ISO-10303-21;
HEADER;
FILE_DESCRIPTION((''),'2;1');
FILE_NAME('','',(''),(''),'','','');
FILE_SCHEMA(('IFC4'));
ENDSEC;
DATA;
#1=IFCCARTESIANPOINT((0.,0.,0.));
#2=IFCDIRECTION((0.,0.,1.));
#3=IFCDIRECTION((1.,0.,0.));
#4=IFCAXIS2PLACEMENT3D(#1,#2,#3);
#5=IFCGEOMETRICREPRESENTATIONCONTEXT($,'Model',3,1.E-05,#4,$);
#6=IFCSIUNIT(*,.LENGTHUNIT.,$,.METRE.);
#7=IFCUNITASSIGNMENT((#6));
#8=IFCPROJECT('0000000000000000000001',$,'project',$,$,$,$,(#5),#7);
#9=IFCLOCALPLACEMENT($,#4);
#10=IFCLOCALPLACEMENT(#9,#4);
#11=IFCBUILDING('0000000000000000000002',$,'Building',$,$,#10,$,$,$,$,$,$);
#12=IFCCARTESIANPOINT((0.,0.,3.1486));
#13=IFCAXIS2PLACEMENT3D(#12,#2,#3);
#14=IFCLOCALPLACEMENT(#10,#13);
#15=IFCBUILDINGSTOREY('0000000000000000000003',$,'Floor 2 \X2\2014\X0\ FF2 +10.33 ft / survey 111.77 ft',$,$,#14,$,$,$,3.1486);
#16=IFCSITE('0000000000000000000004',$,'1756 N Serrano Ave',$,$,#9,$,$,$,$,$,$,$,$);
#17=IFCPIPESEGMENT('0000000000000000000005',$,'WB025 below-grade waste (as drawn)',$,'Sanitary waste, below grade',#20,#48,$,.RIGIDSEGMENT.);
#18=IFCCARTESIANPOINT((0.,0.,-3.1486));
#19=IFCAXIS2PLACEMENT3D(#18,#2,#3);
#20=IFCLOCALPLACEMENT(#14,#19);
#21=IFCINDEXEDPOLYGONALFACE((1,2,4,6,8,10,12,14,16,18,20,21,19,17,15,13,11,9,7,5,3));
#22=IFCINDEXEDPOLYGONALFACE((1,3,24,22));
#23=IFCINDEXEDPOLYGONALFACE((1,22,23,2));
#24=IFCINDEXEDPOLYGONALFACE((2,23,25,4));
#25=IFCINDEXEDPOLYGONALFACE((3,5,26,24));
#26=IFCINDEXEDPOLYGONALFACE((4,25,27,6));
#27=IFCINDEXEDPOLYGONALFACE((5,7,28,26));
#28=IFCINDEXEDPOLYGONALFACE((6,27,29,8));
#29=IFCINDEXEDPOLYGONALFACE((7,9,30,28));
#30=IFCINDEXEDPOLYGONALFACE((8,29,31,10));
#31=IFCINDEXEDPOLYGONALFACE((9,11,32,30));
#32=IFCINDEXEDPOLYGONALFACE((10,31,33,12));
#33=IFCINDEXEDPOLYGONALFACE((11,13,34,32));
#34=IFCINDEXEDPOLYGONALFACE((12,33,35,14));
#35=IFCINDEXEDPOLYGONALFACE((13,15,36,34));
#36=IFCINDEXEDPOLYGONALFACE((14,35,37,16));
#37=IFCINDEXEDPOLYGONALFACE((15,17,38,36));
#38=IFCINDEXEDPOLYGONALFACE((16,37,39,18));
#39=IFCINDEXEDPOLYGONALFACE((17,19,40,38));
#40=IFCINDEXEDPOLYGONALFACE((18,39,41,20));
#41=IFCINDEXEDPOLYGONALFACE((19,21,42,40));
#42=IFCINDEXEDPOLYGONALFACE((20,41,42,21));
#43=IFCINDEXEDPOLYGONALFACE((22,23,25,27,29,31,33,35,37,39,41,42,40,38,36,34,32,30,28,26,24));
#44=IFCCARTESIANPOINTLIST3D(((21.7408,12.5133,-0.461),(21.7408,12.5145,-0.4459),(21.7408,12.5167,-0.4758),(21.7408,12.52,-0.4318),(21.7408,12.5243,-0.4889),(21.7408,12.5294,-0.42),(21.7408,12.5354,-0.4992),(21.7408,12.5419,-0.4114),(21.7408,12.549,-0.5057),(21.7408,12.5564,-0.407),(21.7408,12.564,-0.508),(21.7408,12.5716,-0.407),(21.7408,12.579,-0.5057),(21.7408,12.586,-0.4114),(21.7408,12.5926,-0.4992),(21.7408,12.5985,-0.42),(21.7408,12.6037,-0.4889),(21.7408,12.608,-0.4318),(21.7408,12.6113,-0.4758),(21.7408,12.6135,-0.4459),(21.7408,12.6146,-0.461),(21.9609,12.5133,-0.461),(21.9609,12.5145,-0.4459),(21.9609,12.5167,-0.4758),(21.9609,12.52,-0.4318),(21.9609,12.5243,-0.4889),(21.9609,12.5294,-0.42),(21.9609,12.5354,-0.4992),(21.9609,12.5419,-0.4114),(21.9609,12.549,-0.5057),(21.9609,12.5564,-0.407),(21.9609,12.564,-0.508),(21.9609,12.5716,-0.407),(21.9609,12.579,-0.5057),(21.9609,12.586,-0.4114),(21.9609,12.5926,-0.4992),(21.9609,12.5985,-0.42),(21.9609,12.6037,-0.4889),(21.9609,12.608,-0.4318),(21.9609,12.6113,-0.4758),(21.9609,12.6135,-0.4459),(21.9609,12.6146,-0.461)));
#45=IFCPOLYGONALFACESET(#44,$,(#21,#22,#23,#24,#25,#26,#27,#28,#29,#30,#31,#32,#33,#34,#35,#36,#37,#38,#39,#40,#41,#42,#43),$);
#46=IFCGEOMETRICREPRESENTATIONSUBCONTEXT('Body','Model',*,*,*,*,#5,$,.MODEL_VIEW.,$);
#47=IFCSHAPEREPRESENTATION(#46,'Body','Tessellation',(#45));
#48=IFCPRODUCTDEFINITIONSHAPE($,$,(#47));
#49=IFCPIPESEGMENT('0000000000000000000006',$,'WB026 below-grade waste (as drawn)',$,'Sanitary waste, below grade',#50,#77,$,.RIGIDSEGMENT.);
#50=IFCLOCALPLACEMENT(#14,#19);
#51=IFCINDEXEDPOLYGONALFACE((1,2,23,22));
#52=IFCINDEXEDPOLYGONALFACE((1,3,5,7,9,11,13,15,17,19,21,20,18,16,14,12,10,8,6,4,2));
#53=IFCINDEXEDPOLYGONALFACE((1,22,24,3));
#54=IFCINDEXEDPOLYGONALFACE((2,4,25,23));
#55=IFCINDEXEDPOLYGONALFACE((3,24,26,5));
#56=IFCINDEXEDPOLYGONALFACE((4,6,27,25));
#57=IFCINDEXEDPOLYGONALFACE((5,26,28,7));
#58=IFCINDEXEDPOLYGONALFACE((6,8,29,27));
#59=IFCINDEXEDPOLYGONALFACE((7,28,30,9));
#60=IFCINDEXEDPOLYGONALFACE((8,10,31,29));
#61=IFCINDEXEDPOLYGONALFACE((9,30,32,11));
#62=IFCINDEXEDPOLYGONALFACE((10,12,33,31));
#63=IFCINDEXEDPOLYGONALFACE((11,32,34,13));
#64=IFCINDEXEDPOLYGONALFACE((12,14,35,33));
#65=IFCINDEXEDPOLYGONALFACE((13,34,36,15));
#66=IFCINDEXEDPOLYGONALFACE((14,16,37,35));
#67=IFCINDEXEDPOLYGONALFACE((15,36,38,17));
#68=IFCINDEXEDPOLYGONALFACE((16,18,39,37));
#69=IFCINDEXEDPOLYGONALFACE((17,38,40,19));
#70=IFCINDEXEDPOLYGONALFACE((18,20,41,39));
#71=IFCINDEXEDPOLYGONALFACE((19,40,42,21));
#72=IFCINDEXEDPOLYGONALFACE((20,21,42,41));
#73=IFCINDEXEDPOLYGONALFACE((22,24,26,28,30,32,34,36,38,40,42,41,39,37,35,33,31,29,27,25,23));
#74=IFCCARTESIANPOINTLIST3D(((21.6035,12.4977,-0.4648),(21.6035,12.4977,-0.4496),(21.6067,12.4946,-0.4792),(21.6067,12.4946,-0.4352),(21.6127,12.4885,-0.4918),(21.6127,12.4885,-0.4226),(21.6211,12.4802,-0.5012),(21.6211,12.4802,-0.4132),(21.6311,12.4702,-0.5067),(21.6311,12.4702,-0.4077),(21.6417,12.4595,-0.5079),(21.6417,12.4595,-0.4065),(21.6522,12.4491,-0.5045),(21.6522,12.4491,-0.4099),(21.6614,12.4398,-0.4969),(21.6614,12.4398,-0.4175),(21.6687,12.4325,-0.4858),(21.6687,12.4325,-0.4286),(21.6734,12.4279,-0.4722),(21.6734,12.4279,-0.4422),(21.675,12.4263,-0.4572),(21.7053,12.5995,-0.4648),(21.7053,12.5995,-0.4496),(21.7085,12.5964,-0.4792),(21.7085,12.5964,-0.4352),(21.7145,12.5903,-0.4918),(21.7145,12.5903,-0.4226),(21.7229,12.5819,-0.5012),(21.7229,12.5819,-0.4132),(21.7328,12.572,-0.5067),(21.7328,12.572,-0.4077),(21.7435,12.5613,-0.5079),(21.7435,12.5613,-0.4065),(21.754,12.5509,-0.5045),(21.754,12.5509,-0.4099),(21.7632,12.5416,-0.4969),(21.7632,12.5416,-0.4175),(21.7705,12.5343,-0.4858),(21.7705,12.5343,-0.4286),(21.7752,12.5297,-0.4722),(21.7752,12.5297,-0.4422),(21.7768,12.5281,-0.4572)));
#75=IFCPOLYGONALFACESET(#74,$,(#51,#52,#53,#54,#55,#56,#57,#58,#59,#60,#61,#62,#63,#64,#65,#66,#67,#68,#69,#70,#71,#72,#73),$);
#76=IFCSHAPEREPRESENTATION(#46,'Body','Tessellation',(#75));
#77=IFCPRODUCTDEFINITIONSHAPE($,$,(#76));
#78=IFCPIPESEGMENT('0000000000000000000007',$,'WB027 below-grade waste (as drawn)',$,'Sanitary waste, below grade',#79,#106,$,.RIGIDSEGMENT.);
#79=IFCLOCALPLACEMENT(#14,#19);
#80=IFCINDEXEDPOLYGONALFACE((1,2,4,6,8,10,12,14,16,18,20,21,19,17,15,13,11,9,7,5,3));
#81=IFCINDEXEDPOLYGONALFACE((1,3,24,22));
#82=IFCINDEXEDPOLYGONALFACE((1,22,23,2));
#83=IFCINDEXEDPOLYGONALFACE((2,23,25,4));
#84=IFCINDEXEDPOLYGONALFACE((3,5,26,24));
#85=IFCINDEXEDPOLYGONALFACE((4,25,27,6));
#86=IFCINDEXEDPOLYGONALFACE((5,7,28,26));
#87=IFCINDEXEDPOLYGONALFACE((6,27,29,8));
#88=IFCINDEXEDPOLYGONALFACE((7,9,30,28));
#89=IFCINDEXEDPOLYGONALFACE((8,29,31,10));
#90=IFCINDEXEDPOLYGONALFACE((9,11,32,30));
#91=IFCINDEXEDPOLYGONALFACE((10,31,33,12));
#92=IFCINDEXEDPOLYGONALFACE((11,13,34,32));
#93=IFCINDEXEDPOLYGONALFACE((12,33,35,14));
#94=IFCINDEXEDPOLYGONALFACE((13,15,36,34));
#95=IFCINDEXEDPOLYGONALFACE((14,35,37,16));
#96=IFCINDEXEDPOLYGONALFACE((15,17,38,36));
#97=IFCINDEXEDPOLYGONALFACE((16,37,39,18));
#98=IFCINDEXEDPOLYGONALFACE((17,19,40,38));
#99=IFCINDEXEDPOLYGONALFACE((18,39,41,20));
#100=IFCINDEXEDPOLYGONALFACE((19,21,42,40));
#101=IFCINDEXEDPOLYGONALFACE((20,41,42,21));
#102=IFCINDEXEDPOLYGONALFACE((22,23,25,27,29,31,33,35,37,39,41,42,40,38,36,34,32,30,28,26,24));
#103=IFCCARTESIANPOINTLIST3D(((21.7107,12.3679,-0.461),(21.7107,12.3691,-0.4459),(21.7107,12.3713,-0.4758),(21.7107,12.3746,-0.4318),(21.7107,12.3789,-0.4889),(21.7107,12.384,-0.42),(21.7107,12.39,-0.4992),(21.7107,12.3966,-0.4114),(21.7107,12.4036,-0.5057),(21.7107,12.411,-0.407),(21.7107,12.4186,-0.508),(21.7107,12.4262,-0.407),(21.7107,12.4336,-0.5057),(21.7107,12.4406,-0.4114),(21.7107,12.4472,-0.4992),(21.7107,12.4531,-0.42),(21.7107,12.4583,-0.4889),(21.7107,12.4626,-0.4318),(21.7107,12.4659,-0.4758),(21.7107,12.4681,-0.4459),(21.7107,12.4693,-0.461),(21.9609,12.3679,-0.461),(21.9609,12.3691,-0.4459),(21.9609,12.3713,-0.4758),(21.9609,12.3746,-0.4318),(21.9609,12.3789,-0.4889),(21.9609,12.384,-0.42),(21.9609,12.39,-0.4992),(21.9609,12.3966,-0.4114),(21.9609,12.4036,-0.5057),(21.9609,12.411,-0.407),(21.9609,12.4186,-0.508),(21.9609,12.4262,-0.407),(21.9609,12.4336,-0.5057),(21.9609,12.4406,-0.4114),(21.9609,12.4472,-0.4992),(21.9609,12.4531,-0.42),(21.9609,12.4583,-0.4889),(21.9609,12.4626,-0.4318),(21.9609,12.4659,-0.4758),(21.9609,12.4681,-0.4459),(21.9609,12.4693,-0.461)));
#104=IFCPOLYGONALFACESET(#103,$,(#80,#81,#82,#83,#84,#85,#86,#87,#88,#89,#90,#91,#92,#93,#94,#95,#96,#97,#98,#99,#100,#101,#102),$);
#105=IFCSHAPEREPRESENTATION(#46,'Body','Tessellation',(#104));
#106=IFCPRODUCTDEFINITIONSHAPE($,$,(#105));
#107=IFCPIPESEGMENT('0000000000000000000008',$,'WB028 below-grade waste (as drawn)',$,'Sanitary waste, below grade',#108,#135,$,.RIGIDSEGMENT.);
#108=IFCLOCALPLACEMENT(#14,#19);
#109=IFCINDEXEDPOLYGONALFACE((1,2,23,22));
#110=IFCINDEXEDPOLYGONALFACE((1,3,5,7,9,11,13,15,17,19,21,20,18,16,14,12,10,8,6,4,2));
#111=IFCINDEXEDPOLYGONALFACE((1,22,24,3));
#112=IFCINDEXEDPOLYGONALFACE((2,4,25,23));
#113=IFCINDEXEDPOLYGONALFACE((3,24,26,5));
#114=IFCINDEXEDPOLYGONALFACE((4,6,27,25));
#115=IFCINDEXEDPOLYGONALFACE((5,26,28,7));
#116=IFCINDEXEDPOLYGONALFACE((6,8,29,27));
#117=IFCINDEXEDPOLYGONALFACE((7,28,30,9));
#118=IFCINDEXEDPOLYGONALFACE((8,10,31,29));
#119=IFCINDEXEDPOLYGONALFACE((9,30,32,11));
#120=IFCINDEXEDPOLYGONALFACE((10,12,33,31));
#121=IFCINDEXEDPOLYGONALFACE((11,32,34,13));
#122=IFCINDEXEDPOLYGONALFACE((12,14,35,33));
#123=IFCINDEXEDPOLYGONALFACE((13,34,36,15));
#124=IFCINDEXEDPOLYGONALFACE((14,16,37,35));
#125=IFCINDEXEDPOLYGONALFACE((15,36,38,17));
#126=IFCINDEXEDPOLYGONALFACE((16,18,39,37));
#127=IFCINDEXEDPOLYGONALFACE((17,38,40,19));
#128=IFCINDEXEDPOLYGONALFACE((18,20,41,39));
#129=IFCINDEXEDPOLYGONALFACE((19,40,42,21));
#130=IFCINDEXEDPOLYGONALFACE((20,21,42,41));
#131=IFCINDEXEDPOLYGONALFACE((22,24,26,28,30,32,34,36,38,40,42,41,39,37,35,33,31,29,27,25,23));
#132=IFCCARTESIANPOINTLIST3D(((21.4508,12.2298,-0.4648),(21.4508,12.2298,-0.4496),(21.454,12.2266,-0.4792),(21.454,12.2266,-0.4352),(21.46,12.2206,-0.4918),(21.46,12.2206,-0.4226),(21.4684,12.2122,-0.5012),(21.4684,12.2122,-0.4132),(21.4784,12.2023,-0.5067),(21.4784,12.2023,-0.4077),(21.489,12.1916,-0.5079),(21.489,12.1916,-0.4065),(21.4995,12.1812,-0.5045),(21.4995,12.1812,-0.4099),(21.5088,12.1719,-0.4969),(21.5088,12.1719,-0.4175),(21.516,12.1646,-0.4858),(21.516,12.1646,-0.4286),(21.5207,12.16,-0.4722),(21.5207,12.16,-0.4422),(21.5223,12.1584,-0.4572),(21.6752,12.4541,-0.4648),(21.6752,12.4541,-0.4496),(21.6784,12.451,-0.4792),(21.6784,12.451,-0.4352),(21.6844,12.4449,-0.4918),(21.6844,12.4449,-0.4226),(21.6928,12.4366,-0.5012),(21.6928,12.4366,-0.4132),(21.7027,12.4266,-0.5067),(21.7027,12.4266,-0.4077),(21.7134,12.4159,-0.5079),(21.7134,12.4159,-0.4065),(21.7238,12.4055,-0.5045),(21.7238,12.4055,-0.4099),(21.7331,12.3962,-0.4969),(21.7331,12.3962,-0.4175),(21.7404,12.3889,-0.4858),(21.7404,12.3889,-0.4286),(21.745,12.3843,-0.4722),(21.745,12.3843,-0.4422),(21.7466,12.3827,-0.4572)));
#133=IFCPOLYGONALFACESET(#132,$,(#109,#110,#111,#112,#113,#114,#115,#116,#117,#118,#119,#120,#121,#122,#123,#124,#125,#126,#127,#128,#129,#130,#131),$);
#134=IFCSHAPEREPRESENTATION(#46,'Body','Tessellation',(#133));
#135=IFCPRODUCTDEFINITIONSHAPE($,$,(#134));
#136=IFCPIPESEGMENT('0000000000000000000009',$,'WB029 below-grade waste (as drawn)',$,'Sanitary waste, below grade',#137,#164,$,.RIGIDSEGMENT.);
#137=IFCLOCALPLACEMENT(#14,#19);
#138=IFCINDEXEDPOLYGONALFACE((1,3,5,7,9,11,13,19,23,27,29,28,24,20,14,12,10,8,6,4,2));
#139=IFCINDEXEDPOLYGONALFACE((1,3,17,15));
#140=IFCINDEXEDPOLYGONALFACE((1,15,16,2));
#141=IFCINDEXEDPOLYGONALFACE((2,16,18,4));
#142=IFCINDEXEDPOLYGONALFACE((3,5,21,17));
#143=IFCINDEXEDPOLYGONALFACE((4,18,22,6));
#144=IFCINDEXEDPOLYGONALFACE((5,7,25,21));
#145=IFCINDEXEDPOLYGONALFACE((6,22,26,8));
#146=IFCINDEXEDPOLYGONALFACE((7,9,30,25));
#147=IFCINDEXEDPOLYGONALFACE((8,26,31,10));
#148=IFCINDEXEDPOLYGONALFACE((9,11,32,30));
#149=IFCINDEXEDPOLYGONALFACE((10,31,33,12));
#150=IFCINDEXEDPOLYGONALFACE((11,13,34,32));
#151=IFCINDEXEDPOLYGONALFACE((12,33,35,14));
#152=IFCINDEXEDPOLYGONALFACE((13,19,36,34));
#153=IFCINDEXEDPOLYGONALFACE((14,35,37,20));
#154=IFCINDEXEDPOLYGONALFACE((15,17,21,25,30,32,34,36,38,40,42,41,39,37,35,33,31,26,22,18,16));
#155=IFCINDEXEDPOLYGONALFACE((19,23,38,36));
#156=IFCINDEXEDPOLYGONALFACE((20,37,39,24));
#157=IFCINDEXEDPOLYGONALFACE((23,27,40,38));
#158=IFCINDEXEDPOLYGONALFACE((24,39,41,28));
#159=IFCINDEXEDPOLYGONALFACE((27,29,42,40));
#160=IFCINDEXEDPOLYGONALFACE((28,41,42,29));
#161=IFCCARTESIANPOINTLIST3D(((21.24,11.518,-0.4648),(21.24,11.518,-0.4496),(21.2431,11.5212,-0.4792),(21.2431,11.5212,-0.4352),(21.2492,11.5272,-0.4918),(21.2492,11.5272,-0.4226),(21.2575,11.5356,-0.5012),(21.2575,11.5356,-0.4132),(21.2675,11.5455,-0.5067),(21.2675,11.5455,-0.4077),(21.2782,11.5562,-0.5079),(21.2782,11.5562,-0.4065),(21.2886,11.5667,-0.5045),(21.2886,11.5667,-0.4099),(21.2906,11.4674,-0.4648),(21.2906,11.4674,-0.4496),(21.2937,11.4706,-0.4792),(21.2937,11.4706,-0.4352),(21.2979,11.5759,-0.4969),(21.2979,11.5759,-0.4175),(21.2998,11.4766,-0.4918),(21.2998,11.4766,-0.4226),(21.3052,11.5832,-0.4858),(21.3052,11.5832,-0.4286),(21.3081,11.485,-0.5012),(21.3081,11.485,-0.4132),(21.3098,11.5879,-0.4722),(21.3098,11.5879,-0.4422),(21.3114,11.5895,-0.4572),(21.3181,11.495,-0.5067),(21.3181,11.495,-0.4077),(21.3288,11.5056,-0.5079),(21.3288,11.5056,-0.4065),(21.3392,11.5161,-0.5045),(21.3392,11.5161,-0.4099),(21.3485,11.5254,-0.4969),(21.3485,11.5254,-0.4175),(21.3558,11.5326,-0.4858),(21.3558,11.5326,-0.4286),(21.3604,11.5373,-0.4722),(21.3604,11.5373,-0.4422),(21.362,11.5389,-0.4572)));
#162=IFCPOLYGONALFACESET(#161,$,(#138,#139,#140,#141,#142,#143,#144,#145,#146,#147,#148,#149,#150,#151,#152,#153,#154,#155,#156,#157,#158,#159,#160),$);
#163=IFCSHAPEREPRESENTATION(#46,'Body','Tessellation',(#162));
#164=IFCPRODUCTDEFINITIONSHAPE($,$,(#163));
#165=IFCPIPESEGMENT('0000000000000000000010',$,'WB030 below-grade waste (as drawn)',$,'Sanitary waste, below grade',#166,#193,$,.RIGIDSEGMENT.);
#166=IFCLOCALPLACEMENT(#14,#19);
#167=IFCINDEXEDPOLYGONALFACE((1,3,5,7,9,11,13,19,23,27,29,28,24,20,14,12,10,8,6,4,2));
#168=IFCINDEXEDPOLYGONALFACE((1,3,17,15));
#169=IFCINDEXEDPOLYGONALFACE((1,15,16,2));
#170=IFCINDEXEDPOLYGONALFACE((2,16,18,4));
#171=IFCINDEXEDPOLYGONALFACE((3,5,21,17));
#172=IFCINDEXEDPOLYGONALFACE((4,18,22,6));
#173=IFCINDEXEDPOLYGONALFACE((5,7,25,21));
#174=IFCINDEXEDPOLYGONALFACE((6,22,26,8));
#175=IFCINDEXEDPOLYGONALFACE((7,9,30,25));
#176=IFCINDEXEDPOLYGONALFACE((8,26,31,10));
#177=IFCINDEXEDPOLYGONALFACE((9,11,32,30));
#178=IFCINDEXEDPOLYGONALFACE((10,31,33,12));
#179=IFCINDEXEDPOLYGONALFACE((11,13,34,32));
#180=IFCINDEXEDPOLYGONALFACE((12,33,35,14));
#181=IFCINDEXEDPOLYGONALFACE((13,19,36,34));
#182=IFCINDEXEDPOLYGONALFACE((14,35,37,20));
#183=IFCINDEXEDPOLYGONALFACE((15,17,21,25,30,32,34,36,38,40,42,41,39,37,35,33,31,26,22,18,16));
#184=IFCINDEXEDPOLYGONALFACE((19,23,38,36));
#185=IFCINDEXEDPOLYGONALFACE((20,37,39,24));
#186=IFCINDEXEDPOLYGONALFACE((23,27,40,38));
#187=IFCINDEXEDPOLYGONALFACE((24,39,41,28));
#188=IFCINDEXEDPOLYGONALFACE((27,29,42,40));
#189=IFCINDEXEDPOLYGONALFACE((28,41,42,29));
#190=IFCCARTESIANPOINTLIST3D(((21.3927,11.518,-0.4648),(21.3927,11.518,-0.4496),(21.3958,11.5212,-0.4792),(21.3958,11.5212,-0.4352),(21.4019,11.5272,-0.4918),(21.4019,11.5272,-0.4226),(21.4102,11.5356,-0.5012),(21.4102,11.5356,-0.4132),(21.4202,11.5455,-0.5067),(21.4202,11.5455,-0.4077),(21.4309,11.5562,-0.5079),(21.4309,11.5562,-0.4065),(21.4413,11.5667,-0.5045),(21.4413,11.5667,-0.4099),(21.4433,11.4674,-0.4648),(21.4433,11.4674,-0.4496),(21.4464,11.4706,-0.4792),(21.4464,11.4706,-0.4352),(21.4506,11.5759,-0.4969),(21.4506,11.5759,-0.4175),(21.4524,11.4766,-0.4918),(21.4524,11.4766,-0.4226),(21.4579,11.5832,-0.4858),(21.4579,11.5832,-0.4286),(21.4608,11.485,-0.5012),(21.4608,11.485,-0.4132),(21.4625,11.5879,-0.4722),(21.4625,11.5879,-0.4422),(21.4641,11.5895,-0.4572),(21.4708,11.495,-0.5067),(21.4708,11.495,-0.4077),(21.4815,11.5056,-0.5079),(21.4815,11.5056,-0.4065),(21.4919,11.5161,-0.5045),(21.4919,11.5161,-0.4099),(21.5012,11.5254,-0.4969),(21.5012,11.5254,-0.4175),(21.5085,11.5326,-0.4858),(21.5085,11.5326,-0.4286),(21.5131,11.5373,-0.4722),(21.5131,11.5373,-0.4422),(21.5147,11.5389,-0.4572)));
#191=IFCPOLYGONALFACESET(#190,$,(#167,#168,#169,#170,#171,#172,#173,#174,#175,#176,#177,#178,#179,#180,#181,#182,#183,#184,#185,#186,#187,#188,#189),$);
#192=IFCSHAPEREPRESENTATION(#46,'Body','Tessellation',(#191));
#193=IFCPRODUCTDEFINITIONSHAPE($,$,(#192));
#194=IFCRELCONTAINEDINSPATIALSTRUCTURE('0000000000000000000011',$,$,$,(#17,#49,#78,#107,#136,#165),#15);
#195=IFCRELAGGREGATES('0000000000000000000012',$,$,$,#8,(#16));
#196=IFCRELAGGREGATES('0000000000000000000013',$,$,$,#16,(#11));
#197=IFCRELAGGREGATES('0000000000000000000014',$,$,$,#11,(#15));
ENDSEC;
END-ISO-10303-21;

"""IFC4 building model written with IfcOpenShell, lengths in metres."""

from ifc_helpers import new_model, entity, si_unit, frame, origin_with_axes, place, context, subcontext, project, spatial, element, save


model = new_model("IFC4")

# Units and contexts
model_context = context("Model", 3, precision=1e-05, world=origin_with_axes())
body_context = subcontext(model_context, "Body", "Model", "MODEL_VIEW")
ifc_project = project(units=[si_unit("LENGTHUNIT", "METRE")], contexts=[model_context])

# Site, building, storey
site_placement = place(None, origin_with_axes())
site = spatial("IfcSite", under=ifc_project, at=site_placement, Name="1756 N Serrano Ave")
building_placement = place(site_placement, origin_with_axes())
building = spatial("IfcBuilding", under=site, at=building_placement, Name="Building")
storey_placement = place(building_placement, frame((0.0, 0.0, 3.1486), z_axis=(0.0, 0.0, 1.0), x_axis=(1.0, 0.0, 0.0)))
storey = spatial("IfcBuildingStorey", under=building, at=storey_placement, Name="Floor 2 — FF2 +10.33 ft / survey 111.77 ft", Elevation=3.1486)

# Pipe segments
pipe_segment_1_placement = place(storey_placement, frame((0.0, 0.0, -3.1486), z_axis=(0.0, 0.0, 1.0), x_axis=(1.0, 0.0, 0.0)))
element("IfcPipeSegment", 1, at=pipe_segment_1_placement, inside=storey, Name="WB025 below-grade waste (as drawn)", ObjectType="Sanitary waste, below grade", PredefinedType="RIGIDSEGMENT", context=body_context, shape_type="AdvancedSweptSolid", body=[
    entity("IfcSweptDiskSolid", entity("IfcPolyline", [entity("IfcCartesianPoint", [21.9609, 12.564, -0.4572]), entity("IfcCartesianPoint", [21.7408, 12.564, -0.4572])]), 0.0508),
])
pipe_segment_2_placement = place(storey_placement, frame((0.0, 0.0, -3.1486), z_axis=(0.0, 0.0, 1.0), x_axis=(1.0, 0.0, 0.0)))
element("IfcPipeSegment", 2, at=pipe_segment_2_placement, inside=storey, Name="WB026 below-grade waste (as drawn)", ObjectType="Sanitary waste, below grade", PredefinedType="RIGIDSEGMENT", context=body_context, shape_type="AdvancedSweptSolid", body=[
    entity("IfcSweptDiskSolid", entity("IfcPolyline", [entity("IfcCartesianPoint", [21.7408, 12.564, -0.4572]), entity("IfcCartesianPoint", [21.639, 12.4622, -0.4572])]), 0.0508),
])
pipe_segment_3_placement = place(storey_placement, frame((0.0, 0.0, -3.1486), z_axis=(0.0, 0.0, 1.0), x_axis=(1.0, 0.0, 0.0)))
element("IfcPipeSegment", 3, at=pipe_segment_3_placement, inside=storey, Name="WB027 below-grade waste (as drawn)", ObjectType="Sanitary waste, below grade", PredefinedType="RIGIDSEGMENT", context=body_context, shape_type="AdvancedSweptSolid", body=[
    entity("IfcSweptDiskSolid", entity("IfcPolyline", [entity("IfcCartesianPoint", [21.9609, 12.4186, -0.4572]), entity("IfcCartesianPoint", [21.7107, 12.4186, -0.4572])]), 0.0508),
])
pipe_segment_4_placement = place(storey_placement, frame((0.0, 0.0, -3.1486), z_axis=(0.0, 0.0, 1.0), x_axis=(1.0, 0.0, 0.0)))
element("IfcPipeSegment", 4, at=pipe_segment_4_placement, inside=storey, Name="WB028 below-grade waste (as drawn)", ObjectType="Sanitary waste, below grade", PredefinedType="RIGIDSEGMENT", context=body_context, shape_type="AdvancedSweptSolid", body=[
    entity("IfcSweptDiskSolid", entity("IfcPolyline", [entity("IfcCartesianPoint", [21.7107, 12.4186, -0.4572]), entity("IfcCartesianPoint", [21.4864, 12.1943, -0.4572])]), 0.0508),
])
pipe_segment_5_placement = place(storey_placement, frame((0.0, 0.0, -3.1486), z_axis=(0.0, 0.0, 1.0), x_axis=(1.0, 0.0, 0.0)))
element("IfcPipeSegment", 5, at=pipe_segment_5_placement, inside=storey, Name="WB029 below-grade waste (as drawn)", ObjectType="Sanitary waste, below grade", PredefinedType="RIGIDSEGMENT", context=body_context, shape_type="AdvancedSweptSolid", body=[
    entity("IfcSweptDiskSolid", entity("IfcPolyline", [entity("IfcCartesianPoint", [21.2755, 11.5535, -0.4572]), entity("IfcCartesianPoint", [21.3261, 11.503, -0.4572])]), 0.0508),
])
pipe_segment_6_placement = place(storey_placement, frame((0.0, 0.0, -3.1486), z_axis=(0.0, 0.0, 1.0), x_axis=(1.0, 0.0, 0.0)))
element("IfcPipeSegment", 6, at=pipe_segment_6_placement, inside=storey, Name="WB030 below-grade waste (as drawn)", ObjectType="Sanitary waste, below grade", PredefinedType="RIGIDSEGMENT", context=body_context, shape_type="AdvancedSweptSolid", body=[
    entity("IfcSweptDiskSolid", entity("IfcPolyline", [entity("IfcCartesianPoint", [21.4282, 11.5535, -0.4572]), entity("IfcCartesianPoint", [21.4788, 11.503, -0.4572])]), 0.0508),
])

save(model, "model.ifc")
